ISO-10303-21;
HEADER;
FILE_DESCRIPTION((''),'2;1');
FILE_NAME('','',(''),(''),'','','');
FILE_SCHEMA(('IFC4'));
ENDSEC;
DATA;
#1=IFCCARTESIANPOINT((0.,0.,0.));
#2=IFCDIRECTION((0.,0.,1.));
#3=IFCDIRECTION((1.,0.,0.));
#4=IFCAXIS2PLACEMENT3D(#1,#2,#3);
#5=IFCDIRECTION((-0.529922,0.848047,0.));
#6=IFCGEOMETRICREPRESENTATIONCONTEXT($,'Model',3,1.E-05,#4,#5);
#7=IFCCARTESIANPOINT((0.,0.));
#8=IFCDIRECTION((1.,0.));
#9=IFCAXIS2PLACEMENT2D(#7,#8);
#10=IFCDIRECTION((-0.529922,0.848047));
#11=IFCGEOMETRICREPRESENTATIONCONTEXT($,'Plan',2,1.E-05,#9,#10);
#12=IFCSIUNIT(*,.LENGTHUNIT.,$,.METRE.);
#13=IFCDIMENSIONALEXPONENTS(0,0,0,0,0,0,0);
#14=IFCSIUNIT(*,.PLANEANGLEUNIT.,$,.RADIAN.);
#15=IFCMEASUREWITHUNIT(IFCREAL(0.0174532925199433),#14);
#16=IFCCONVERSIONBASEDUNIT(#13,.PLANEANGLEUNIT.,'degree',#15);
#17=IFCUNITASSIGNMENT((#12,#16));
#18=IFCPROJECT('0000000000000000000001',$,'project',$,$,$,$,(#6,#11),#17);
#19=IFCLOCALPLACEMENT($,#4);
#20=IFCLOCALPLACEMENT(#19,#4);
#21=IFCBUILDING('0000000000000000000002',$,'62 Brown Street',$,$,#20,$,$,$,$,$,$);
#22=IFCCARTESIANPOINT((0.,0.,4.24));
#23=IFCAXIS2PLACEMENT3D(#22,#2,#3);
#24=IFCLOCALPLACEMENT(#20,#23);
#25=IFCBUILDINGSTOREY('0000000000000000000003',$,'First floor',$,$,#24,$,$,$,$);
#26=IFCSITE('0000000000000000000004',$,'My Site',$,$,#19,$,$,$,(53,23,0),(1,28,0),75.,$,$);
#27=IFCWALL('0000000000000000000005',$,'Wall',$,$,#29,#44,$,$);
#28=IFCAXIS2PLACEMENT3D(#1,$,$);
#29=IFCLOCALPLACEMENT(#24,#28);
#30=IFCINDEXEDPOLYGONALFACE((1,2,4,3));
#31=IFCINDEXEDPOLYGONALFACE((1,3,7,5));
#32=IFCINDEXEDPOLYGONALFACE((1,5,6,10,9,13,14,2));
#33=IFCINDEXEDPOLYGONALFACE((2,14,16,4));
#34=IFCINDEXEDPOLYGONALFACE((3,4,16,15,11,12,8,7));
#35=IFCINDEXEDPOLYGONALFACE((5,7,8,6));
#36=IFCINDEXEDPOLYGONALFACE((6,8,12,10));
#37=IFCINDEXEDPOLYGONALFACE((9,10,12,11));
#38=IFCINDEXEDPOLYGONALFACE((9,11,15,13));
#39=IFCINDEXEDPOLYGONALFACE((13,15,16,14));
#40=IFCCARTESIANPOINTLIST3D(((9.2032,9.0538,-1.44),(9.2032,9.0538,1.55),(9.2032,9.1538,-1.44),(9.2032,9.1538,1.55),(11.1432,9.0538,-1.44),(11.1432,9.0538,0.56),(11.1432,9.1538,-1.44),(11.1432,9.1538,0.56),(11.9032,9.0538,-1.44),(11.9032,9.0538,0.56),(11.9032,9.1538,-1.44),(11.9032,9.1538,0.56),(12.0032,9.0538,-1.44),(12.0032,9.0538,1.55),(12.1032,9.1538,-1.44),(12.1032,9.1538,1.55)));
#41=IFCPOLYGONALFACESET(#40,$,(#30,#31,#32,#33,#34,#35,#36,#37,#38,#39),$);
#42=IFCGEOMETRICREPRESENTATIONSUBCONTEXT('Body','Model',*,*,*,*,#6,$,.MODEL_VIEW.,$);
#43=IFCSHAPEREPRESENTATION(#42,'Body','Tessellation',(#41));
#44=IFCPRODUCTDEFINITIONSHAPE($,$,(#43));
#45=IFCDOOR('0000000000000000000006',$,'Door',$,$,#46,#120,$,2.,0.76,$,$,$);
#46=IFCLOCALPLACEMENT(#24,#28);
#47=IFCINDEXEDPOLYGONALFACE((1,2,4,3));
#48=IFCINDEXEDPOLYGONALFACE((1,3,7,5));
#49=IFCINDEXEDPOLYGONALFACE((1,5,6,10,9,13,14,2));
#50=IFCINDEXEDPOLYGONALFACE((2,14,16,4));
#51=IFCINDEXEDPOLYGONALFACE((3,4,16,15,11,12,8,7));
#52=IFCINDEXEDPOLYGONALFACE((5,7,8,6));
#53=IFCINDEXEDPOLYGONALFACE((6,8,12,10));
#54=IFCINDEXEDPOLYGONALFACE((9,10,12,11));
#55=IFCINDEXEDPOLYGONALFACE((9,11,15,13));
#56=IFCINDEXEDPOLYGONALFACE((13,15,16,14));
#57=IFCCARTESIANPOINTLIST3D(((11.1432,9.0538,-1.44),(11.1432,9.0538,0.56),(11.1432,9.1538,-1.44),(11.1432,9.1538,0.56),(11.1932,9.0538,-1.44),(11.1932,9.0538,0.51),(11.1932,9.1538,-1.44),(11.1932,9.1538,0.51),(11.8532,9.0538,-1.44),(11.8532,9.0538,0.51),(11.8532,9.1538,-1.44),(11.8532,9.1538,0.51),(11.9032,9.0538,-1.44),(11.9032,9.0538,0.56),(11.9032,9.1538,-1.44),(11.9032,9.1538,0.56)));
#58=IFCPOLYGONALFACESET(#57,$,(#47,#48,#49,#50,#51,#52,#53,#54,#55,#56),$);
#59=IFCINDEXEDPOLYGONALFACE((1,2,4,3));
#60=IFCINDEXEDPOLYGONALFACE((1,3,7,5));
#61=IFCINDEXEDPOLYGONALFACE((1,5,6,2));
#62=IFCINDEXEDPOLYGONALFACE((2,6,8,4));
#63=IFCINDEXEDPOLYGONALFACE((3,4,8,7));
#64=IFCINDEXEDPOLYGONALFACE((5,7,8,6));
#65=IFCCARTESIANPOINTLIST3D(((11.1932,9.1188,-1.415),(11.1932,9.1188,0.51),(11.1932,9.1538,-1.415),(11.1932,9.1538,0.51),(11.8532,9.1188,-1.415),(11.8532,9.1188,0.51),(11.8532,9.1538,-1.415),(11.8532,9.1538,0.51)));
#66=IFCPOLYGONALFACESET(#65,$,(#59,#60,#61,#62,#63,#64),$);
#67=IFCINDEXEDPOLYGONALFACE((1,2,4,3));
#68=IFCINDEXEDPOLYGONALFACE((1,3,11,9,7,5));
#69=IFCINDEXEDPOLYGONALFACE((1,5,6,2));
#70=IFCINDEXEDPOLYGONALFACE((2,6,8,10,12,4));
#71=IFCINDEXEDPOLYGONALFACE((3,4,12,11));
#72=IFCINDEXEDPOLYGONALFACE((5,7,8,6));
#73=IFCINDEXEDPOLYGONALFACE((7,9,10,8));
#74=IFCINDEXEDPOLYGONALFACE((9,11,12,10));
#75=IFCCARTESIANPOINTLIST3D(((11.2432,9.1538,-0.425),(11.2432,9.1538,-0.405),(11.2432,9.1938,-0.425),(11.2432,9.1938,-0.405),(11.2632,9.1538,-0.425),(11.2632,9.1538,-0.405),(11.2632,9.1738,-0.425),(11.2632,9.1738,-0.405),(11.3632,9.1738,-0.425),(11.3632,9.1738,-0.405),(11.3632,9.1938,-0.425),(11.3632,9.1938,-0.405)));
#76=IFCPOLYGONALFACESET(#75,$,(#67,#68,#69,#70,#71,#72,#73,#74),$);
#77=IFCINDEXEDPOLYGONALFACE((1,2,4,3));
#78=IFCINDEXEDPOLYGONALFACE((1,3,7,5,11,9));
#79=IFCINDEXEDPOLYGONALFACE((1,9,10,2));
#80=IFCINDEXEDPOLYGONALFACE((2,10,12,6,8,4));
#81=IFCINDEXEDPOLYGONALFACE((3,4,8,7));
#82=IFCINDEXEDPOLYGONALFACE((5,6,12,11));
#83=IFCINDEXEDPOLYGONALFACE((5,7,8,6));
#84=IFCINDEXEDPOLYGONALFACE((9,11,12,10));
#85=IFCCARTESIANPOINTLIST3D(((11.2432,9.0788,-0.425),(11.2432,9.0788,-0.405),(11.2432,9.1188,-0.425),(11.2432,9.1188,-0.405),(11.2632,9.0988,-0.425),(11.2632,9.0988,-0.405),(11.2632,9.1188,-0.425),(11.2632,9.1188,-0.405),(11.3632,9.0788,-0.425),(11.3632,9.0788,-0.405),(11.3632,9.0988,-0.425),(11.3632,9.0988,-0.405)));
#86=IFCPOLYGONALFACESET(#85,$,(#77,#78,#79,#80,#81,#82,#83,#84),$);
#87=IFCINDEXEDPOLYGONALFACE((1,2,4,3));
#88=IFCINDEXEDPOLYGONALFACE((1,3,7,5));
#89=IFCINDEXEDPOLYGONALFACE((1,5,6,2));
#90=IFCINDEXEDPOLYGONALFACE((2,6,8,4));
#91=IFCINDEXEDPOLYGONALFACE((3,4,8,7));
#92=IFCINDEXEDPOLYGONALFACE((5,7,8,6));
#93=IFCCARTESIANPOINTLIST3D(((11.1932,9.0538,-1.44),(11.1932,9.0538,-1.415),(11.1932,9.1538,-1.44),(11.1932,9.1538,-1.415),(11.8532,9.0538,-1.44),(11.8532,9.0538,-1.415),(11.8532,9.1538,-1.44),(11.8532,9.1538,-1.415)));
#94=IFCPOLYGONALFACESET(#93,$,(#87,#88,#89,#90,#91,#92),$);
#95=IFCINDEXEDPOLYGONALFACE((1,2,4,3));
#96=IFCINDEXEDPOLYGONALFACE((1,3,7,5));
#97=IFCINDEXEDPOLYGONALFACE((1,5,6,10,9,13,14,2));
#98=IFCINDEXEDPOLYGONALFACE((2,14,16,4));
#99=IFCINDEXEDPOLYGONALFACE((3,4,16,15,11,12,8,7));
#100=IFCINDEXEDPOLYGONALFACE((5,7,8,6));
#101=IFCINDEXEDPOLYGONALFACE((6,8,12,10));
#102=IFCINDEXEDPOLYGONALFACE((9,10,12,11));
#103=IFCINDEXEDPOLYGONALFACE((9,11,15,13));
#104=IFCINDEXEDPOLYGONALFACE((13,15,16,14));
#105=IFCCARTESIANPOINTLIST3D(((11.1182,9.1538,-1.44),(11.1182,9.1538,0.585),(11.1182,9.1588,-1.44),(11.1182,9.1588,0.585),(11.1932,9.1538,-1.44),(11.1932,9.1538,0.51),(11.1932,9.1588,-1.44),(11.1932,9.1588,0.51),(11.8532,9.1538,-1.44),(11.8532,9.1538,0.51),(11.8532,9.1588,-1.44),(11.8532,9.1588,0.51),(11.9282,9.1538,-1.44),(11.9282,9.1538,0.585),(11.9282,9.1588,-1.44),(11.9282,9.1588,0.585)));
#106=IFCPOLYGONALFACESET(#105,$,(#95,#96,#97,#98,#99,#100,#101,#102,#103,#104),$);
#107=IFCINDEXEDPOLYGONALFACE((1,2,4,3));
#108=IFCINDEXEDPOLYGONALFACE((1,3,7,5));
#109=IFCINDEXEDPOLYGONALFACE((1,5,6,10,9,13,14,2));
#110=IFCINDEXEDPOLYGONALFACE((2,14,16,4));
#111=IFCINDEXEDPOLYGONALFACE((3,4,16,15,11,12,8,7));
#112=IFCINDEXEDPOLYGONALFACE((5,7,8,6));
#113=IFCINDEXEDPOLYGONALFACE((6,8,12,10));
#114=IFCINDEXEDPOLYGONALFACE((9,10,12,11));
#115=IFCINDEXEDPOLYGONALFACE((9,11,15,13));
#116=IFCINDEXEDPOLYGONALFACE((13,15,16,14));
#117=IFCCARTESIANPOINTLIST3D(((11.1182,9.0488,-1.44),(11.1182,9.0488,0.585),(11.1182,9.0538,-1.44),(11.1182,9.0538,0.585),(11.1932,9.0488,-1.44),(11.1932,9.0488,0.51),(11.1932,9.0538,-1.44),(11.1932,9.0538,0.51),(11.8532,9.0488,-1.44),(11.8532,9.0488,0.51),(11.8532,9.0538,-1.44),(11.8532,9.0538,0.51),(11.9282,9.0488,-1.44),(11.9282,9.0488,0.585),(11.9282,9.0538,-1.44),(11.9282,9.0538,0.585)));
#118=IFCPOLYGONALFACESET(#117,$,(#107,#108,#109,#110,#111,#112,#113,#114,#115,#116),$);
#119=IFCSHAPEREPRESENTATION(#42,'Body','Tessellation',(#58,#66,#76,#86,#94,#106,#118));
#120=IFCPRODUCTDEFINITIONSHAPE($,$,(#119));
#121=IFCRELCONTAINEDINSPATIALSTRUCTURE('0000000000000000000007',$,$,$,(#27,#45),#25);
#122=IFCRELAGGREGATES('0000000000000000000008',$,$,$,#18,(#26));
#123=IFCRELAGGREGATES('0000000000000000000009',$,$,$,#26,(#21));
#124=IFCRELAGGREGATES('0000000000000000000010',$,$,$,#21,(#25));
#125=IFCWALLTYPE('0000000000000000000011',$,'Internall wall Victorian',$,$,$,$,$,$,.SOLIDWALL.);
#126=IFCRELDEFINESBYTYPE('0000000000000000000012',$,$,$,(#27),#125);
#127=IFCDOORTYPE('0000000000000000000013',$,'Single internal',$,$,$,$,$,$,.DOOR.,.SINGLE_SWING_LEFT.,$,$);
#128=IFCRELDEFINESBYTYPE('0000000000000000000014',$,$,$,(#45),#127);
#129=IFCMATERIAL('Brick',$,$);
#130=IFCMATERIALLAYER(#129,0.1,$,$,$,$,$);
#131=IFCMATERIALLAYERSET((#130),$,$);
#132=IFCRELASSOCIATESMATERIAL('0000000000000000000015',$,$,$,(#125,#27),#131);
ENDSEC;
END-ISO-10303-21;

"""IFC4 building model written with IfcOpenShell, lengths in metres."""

from ifc_helpers import new_model, entity, si_unit, converted_unit, direction, frame, origin_with_axes, origin_2d_with_axis, place, context, subcontext, project, spatial, line, indexed_curve, outline, extrude, clip, halfspace, shape, source, transform, mapped, material, layer, layer_set, layer_usage, type_object, type_shapes, element, fill, save


model = new_model("IFC4")

# Units and contexts
model_context = context("Model", 3, precision=1e-05, world=origin_with_axes(), true_north=direction((-0.529922, 0.848047, 0.0)))
plan_context = context("Plan", 2, precision=1e-05, world=origin_2d_with_axis(), true_north=direction((-0.529922, 0.848047)))
body_context_1 = subcontext(model_context, "Body", "Model", "MODEL_VIEW")
body_context_2 = subcontext(plan_context, "Body", "Plan", "PLAN_VIEW")
ifc_project = project(units=[si_unit("LENGTHUNIT", "METRE"), converted_unit("PLANEANGLEUNIT", "degree", entity("IfcReal", 0.0174532925199433), si_unit("PLANEANGLEUNIT", "RADIAN"), dimensions=[0, 0, 0, 0, 0, 0, 0])], contexts=[model_context, plan_context])

# Site, building, storey
site_placement = place(None, origin_with_axes())
site = spatial("IfcSite", under=ifc_project, at=site_placement, Name="My Site", RefLatitude=(53, 23, 0), RefLongitude=(1, 28, 0), RefElevation=75.0)
building_placement = place(site_placement, origin_with_axes())
building = spatial("IfcBuilding", under=site, at=building_placement, Name="62 Brown Street")
storey_placement = place(building_placement, frame((0.0, 0.0, 4.24), z_axis=(0.0, 0.0, 1.0), x_axis=(1.0, 0.0, 0.0)))
storey = spatial("IfcBuildingStorey", under=building, at=storey_placement, Name="First floor")

# Shared definitions
ifc_material_1 = material(Name="Brick")
ifc_layer_1 = layer(ifc_material_1, 0.1)
ifc_layer_set_1 = layer_set([ifc_layer_1])
wall_type_1 = type_object("IfcWallType", Name="Internall wall Victorian", PredefinedType="SOLIDWALL", material=ifc_layer_set_1)

# Wall, opening, door
ifc_layer_usage_1 = layer_usage(ifc_layer_set_1, "AXIS2", "POSITIVE", 0.0)
wall_1_placement = place(storey_placement, frame((12.1032, 9.1538, -1.44), z_axis=(0.0, 0.0, 1.0), x_axis=(-1.0, 0.0, 0.0)))
wall_1 = element("IfcWall", 1, at=wall_1_placement, inside=storey, type_object=wall_type_1, material=ifc_layer_usage_1, Name="Wall", context=body_context_1, shape_type="Clipping", body=[
    clip(extrude(outline(indexed_curve([(0.0, 0.0), (0.0, 0.1), (2.9, 0.1), (2.9, 0.0), (0.0, 0.0)], self_intersect=False)), origin_with_axes(), (0.0, 0.0, 1.0), 2.99), halfspace(frame((0.0, 0.0, -2.8), z_axis=(-0.299001, 0.299001, 0.0), x_axis=(0.1, 0.1, 0.0)), False)),
])
shared_shape_1 = source(origin_with_axes(), body_context_1, "Body", "SweptSolid", [
    extrude(outline(indexed_curve([(0.0, 0.0), (0.76, 0.0), (0.76, 2.0), (0.0, 2.0)], segments=[line(1, 2, 3, 4, 1)])), frame((0.0, -0.6, 0.0), z_axis=(0.0, -1.0, 0.0), x_axis=(1.0, 0.0, 0.0)), (0.0, 0.0, -1.0), 1.2),
])
opening_placement = place(wall_1_placement, frame((0.2, 0.0, 0.0), z_axis=(0.0, 0.0, 1.0), x_axis=(1.0, 0.0, 0.0)))
opening = element("IfcOpeningElement", 2, at=opening_placement, cuts=wall_1, PredefinedType="OPENING", context=body_context_1, shape_type="MappedRepresentation", body=[
    mapped(shared_shape_1, transform((0.0, 0.0, 0.0), x_axis=(1.0, 0.0, 0.0), y_axis=(0.0, 1.0, 0.0), z_axis=(0.0, 0.0, 1.0), scale=1.0)),
])
door_type = type_object("IfcDoorType", Name="Single internal", OperationType="SINGLE_SWING_LEFT", PredefinedType="DOOR")
shared_shape_2 = source(origin_with_axes(), body_context_1, "Body", "SweptSolid", [
    extrude(outline(indexed_curve([(0.0, 0.0), (0.0, 2.0), (0.76, 2.0), (0.76, 0.0), (0.71, 0.0), (0.71, 1.95), (0.05, 1.95), (0.05, 0.0)], segments=[line(1, 2, 3, 4, 5, 6, 7, 8, 1)])), frame((0.0, 0.0, 0.0), z_axis=(0.0, -1.0, 0.0), x_axis=(1.0, 0.0, 0.0)), (0.0, 0.0, -1.0), 0.1),
    extrude(outline(indexed_curve([(0.0, 0.0), (0.66, 0.0), (0.66, 0.035), (0.0, 0.035)], segments=[line(1, 2, 3, 4, 1)])), frame((0.05, 0.0, 0.025), z_axis=(0.0, 0.0, 1.0), x_axis=(1.0, 0.0, 0.0)), (0.0, 0.0, 1.0), 1.925),
    extrude(outline(indexed_curve([(0.0, 0.0), (0.0, -0.04), (-0.12, -0.04), (-0.12, -0.02), (-0.02, -0.02), (-0.02, 0.0)], segments=[line(1, 2, 3, 4, 5, 6, 1)])), frame((0.66, 0.0, 1.015), z_axis=(0.0, 0.0, 1.0), x_axis=(1.0, 0.0, 0.0)), (0.0, 0.0, 1.0), 0.02),
    extrude(outline(indexed_curve([(0.0, 0.0), (0.0, 0.04), (-0.12, 0.04), (-0.12, 0.02), (-0.02, 0.02), (-0.02, 0.0)], segments=[line(1, 2, 3, 4, 5, 6, 1)])), frame((0.66, 0.035, 1.015), z_axis=(0.0, 0.0, 1.0), x_axis=(1.0, 0.0, 0.0)), (0.0, 0.0, 1.0), 0.02),
    extrude(outline(indexed_curve([(0.0, 0.0), (0.66, 0.0), (0.66, 0.1), (0.0, 0.1)], segments=[line(1, 2, 3, 4, 1)])), frame((0.05, 0.0, 0.0), z_axis=(0.0, 0.0, 1.0), x_axis=(1.0, 0.0, 0.0)), (0.0, 0.0, 1.0), 0.025),
    extrude(outline(indexed_curve([(0.0, 0.0), (0.0, 2.025), (0.81, 2.025), (0.81, 0.0), (0.735, 0.0), (0.735, 1.95), (0.075, 1.95), (0.075, 0.0)], segments=[line(1, 2, 3, 4, 5, 6, 7, 8, 1)])), frame((-0.025, -0.005, 0.0), z_axis=(0.0, -1.0, 0.0), x_axis=(1.0, 0.0, 0.0)), (0.0, 0.0, -1.0), 0.005),
    extrude(outline(indexed_curve([(0.0, 0.0), (0.0, 2.025), (0.81, 2.025), (0.81, 0.0), (0.735, 0.0), (0.735, 1.95), (0.075, 1.95), (0.075, 0.0)], segments=[line(1, 2, 3, 4, 5, 6, 7, 8, 1)])), frame((-0.025, 0.1, 0.0), z_axis=(0.0, -1.0, 0.0), x_axis=(1.0, 0.0, 0.0)), (0.0, 0.0, -1.0), 0.005),
])
shared_shape_3 = source(origin_with_axes(), body_context_2, "Body", "Curve2D", [
    entity("IfcIndexedPolyCurve", entity("IfcCartesianPointList2D", [[0.0, 0.0], [0.05, 0.0], [0.05, 0.1], [0.0, 0.1]]), [entity("IfcLineIndex", [1, 2, 3, 4, 1])]),
    entity("IfcIndexedPolyCurve", entity("IfcCartesianPointList2D", [[0.76, 0.0], [0.71, 0.0], [0.71, 0.1], [0.76, 0.1]]), [entity("IfcLineIndex", [1, 2, 3, 4, 1])]),
    entity("IfcTrimmedCurve", entity("IfcEllipse", entity("IfcAxis2Placement2D", entity("IfcCartesianPoint", [0.085, 0.1]), entity("IfcDirection", [1.0, 0.0])), 0.625, 0.66), [entity("IfcCartesianPoint", [0.71, 0.1])], [entity("IfcCartesianPoint", [0.085, 0.76])], True, "CARTESIAN"),
    entity("IfcIndexedPolyCurve", entity("IfcCartesianPointList2D", [[0.05, 0.1], [0.085, 0.1], [0.085, 0.76], [0.05, 0.76]]), [entity("IfcLineIndex", [1, 2, 3, 4, 1])]),
])
type_shapes(door_type, [shared_shape_2, shared_shape_3])
door_placement = place(opening_placement, frame((0.0, 0.0, 0.0), z_axis=(0.0, 0.0, 1.0), x_axis=(1.0, 0.0, 0.0)))
door = element("IfcDoor", 3, at=door_placement, inside=storey, type_object=door_type, Name="Door", OverallHeight=2.0, OverallWidth=0.76, shapes=[
    shape(body_context_1, "Body", "MappedRepresentation", [mapped(shared_shape_2, transform((0.0, 0.0, 0.0), x_axis=(1.0, 0.0, 0.0), y_axis=(0.0, 1.0, 0.0), z_axis=(0.0, 0.0, 1.0), scale=1.0))]),
    shape(body_context_2, "Body", "MappedRepresentation", [mapped(shared_shape_3, transform((0.0, 0.0, 0.0), x_axis=(1.0, 0.0, 0.0), y_axis=(0.0, 1.0, 0.0), z_axis=(0.0, 0.0, 1.0), scale=1.0))]),
])
fill(opening, door)

save(model, "model.ifc")
